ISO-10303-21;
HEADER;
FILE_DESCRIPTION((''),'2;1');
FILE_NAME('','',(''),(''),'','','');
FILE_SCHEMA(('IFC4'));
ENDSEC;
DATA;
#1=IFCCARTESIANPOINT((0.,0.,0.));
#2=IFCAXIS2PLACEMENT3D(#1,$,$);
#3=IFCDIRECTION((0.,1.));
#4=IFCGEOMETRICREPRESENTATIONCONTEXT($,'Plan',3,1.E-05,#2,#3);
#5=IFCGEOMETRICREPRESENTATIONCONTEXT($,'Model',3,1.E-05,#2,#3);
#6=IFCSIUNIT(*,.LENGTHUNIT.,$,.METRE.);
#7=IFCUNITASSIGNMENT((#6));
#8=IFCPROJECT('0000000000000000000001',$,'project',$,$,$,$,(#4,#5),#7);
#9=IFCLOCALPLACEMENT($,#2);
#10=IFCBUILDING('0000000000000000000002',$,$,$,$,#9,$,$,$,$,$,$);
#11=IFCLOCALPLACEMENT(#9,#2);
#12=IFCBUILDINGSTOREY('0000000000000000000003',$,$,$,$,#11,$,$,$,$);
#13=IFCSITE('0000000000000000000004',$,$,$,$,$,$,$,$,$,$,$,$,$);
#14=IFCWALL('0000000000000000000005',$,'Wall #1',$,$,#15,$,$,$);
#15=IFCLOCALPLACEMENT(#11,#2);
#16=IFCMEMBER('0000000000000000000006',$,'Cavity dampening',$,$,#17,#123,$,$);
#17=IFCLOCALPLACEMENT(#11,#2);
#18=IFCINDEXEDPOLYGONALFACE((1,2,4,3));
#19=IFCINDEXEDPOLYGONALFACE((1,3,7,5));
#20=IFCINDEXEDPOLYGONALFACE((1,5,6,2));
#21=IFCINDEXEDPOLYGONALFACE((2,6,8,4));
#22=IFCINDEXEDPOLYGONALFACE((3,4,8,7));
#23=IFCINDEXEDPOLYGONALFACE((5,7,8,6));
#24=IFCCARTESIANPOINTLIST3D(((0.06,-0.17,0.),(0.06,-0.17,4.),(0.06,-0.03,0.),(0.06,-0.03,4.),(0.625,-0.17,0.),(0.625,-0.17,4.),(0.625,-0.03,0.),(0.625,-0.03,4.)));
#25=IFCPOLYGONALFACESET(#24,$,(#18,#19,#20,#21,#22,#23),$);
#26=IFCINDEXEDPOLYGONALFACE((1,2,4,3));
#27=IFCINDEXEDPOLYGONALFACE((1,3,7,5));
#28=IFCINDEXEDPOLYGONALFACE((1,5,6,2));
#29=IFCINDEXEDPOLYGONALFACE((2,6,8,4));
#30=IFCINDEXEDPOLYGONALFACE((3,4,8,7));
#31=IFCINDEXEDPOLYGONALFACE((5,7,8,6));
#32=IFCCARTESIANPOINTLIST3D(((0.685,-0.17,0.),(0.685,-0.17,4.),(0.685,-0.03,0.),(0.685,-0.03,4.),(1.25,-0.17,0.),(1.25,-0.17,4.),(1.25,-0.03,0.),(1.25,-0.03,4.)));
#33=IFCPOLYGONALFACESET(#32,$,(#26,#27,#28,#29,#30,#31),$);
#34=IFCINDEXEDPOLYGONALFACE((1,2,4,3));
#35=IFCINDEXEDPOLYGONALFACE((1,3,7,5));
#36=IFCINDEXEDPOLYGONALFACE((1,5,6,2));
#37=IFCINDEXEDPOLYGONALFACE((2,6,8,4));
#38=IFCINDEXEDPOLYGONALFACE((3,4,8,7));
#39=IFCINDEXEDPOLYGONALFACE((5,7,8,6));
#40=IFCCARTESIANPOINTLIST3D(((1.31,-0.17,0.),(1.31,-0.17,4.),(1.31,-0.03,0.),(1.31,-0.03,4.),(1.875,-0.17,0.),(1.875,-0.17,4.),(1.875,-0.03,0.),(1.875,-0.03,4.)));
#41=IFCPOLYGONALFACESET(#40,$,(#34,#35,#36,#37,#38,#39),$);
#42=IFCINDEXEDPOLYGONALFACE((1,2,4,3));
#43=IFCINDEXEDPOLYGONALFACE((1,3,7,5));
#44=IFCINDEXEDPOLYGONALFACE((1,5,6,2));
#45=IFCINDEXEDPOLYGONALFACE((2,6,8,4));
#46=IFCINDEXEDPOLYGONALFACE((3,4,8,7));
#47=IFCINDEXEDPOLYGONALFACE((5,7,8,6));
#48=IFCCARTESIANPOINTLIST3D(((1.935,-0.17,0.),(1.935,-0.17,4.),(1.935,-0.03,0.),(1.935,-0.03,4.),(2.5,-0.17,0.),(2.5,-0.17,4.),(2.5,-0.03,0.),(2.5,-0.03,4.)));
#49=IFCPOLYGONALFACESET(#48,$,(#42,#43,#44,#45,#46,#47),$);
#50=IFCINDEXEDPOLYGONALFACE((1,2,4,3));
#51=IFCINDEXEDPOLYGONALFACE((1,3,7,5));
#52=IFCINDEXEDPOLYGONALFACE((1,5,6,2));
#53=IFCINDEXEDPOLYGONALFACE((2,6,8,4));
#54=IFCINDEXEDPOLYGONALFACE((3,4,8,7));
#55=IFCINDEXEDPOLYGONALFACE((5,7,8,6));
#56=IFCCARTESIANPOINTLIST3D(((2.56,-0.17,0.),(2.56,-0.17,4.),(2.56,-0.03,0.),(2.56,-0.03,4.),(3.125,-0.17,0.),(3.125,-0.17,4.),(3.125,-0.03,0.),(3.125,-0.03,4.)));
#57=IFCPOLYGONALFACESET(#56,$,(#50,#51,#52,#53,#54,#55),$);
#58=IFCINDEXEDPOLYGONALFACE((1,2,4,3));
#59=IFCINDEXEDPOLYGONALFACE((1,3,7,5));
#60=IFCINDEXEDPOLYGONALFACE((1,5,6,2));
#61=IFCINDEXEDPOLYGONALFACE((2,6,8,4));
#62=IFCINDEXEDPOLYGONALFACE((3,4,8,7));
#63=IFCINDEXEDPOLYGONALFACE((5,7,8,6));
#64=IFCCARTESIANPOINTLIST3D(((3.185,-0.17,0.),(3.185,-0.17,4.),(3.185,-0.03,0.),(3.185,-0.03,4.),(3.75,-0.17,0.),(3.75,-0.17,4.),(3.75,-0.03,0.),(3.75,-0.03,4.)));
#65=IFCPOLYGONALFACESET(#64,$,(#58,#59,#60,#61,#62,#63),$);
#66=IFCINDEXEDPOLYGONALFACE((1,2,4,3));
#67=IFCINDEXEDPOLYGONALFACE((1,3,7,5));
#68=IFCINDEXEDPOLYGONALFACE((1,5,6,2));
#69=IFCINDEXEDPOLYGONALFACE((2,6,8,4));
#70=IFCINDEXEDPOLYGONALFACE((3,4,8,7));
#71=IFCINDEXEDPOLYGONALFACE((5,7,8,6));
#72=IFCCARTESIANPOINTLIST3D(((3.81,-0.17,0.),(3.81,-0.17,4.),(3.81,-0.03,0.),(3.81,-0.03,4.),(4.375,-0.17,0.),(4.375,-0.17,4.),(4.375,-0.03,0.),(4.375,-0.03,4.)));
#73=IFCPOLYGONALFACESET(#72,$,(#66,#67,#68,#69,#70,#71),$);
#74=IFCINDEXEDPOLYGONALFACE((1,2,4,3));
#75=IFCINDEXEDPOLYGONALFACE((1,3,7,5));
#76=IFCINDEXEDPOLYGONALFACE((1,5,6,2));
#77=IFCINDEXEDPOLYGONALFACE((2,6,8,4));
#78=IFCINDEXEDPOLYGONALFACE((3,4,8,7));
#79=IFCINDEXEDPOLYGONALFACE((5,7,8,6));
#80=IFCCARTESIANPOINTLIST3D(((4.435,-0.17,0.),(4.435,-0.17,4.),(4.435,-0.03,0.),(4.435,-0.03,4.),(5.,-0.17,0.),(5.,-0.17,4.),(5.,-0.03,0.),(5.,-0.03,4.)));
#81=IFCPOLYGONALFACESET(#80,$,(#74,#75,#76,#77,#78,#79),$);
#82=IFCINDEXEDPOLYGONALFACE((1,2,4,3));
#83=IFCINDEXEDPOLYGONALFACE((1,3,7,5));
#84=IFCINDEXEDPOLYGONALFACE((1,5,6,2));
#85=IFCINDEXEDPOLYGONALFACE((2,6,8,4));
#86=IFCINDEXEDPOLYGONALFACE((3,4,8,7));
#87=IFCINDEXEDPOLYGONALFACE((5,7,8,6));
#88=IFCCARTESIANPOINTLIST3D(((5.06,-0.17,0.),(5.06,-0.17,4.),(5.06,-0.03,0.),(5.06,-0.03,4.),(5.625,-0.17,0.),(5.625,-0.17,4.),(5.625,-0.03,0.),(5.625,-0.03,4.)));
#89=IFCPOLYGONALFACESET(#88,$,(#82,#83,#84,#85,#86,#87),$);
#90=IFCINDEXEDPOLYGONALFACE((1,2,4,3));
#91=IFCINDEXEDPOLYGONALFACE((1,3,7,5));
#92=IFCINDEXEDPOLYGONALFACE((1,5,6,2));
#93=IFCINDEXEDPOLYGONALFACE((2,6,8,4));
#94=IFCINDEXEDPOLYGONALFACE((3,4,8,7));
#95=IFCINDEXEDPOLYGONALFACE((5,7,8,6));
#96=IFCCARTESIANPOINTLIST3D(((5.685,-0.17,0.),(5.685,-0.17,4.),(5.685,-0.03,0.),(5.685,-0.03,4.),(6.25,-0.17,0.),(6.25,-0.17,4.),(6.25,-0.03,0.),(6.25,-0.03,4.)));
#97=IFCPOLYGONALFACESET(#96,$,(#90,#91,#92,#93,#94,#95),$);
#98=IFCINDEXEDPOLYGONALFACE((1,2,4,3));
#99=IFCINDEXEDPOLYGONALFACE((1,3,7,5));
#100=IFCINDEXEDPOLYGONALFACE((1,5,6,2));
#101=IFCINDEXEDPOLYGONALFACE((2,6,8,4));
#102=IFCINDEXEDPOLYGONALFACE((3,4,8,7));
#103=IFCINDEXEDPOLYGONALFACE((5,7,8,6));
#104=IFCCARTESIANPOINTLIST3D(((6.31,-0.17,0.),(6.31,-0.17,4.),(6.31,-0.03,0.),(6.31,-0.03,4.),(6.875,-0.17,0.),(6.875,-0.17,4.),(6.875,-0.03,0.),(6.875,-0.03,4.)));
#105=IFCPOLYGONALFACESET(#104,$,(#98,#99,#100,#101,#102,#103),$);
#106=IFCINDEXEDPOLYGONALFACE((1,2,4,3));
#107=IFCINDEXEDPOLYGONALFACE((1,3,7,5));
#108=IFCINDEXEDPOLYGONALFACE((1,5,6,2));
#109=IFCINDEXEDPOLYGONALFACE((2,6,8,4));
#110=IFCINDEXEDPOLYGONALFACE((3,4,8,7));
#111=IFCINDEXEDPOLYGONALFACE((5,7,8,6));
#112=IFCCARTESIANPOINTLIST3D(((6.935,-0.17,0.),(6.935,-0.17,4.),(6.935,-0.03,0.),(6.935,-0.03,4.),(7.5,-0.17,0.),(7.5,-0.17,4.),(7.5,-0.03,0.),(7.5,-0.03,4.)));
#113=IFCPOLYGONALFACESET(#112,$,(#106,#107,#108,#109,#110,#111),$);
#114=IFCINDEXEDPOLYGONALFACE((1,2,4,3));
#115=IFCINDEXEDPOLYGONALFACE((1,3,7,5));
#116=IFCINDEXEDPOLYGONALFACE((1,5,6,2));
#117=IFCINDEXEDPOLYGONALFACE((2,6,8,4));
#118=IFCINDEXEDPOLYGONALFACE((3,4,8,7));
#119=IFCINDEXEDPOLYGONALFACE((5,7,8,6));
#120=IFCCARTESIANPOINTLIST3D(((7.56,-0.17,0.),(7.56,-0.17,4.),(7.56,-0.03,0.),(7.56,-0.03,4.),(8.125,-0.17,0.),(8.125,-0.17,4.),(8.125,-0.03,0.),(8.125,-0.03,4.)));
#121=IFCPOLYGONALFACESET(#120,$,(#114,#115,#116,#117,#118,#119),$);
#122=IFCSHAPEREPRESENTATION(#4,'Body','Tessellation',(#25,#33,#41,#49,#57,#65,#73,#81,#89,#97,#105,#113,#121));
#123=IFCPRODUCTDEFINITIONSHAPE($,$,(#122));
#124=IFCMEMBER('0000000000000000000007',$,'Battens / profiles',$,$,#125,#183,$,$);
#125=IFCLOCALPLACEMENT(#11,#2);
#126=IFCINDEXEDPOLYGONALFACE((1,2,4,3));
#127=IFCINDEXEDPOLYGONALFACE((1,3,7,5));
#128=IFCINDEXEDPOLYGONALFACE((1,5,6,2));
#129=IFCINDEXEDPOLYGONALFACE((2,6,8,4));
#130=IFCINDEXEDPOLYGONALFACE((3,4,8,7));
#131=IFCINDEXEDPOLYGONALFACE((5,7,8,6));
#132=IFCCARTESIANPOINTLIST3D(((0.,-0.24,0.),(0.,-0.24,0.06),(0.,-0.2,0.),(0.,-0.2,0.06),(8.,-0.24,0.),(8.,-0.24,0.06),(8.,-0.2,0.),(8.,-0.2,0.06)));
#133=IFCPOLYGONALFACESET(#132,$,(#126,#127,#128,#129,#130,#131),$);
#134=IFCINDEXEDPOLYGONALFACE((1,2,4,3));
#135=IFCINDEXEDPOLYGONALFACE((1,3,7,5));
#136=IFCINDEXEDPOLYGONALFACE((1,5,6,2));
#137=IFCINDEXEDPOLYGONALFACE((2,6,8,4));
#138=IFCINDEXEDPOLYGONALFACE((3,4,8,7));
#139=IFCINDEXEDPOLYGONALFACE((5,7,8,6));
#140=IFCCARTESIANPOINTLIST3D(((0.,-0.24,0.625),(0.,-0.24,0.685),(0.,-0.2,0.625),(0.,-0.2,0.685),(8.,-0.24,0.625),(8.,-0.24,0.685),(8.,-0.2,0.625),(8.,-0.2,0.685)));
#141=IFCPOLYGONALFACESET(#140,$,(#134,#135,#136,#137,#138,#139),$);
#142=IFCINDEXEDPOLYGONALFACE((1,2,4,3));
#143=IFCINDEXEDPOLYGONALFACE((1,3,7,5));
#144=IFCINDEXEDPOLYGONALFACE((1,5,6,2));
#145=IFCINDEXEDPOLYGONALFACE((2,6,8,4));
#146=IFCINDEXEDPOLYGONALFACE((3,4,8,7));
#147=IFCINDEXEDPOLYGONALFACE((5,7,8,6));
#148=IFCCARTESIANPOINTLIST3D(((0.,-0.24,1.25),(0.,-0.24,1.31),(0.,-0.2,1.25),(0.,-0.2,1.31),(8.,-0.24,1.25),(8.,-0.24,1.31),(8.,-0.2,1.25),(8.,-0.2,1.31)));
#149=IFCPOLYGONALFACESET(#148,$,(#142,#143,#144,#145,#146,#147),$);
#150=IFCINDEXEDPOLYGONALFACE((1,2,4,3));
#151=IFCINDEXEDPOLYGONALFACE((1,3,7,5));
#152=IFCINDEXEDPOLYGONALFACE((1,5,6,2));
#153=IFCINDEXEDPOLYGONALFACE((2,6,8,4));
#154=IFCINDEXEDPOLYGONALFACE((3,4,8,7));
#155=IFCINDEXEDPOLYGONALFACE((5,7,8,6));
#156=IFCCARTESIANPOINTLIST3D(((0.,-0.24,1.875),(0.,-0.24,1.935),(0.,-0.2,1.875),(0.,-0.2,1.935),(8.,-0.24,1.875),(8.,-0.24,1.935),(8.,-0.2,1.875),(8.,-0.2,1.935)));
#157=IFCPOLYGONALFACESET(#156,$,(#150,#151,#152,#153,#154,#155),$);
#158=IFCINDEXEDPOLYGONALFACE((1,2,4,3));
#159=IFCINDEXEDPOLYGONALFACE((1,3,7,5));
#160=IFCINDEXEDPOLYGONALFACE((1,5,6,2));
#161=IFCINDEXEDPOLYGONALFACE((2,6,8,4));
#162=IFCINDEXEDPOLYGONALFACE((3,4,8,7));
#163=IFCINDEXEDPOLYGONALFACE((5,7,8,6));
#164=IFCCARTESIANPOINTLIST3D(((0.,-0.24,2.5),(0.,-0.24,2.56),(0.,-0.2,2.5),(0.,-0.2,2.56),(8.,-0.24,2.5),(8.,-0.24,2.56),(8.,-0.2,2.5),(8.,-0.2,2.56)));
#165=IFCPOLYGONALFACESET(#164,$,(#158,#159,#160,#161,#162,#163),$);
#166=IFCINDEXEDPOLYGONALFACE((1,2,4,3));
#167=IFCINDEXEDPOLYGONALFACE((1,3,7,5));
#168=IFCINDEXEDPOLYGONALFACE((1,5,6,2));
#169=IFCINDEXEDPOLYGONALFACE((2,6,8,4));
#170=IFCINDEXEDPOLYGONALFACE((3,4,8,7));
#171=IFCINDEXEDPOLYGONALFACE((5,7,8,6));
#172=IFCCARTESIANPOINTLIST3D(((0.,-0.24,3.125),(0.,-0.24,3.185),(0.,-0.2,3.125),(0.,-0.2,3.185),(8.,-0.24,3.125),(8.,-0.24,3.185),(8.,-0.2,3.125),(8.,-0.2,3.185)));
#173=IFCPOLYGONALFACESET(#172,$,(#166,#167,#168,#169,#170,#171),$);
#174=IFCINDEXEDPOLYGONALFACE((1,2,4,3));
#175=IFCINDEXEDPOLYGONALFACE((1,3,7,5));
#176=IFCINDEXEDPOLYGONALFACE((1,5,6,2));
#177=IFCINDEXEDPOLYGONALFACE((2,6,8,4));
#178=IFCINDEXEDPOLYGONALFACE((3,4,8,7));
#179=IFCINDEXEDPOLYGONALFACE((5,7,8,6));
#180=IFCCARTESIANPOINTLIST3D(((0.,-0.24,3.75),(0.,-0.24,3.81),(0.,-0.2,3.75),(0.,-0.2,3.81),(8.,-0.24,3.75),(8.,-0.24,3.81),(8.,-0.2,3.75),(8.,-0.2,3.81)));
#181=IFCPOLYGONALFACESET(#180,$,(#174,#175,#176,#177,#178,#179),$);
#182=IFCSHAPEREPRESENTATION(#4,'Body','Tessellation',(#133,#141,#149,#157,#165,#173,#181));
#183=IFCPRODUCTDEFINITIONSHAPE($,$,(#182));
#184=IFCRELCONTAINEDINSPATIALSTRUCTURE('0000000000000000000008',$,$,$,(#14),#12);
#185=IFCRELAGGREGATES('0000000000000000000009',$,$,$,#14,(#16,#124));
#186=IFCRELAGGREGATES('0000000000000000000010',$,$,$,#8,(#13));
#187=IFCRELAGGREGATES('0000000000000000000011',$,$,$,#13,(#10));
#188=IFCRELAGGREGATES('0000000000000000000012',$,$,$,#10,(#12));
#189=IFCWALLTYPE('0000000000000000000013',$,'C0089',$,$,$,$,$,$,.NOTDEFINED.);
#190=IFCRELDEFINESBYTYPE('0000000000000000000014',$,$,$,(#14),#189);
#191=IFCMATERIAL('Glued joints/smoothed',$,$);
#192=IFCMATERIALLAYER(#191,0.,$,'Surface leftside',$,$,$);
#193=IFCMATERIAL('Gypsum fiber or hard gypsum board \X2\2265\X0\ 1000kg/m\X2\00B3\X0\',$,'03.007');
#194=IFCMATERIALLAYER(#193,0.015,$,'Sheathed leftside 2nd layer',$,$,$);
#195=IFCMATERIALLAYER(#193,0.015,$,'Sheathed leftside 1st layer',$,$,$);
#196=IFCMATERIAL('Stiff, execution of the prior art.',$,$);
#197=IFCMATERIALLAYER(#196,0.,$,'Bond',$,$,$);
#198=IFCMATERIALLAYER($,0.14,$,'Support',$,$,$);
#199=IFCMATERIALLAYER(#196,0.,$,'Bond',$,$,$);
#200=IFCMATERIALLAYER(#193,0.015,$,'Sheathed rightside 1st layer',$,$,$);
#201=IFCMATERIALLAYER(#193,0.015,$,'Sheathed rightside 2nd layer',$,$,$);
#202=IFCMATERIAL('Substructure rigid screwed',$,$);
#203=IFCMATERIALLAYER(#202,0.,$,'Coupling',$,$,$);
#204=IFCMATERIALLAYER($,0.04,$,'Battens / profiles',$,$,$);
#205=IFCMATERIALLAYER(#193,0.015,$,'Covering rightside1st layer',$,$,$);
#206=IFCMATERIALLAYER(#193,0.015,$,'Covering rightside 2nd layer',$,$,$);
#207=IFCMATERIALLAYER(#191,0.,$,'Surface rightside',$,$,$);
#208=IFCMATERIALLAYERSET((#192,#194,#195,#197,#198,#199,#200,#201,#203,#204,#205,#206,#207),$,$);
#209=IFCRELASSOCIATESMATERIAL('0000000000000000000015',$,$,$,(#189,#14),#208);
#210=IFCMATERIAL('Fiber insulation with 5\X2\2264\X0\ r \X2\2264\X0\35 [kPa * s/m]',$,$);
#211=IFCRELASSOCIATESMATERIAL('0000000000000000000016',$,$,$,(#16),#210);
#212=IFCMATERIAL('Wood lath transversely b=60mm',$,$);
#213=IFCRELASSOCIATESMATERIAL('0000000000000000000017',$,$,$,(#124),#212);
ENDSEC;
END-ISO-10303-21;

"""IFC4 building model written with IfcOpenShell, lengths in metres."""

from ifc_helpers import new_model, si_unit, direction, frame, frame_2d, origin, place, context, project, spatial, rectangle, extrude, material, layer, layer_set, type_object, element, aggregate, save


model = new_model("IFC4")

# Units and contexts
plan_context = context("Plan", 3, precision=1e-05, world=origin(), true_north=direction((0.0, 1.0)))
model_context = context("Model", 3, precision=1e-05, world=origin(), true_north=direction((0.0, 1.0)))
ifc_project = project(units=[si_unit("LENGTHUNIT", "METRE")], contexts=[plan_context, model_context])

# Site, building, storey
site = spatial("IfcSite", under=ifc_project)
building_placement = place(None, origin())
building = spatial("IfcBuilding", under=site, at=building_placement)
storey_placement = place(building_placement, origin())
storey = spatial("IfcBuildingStorey", under=building, at=storey_placement)

# Wall, members
ifc_material_1 = material(Name="Glued joints/smoothed")
ifc_layer_1 = layer(ifc_material_1, 0.0, Name="Surface leftside")
ifc_material_2 = material(Name="Gypsum fiber or hard gypsum board ≥ 1000kg/m³", Category="03.007")
ifc_layer_2 = layer(ifc_material_2, 0.015, Name="Sheathed leftside 2nd layer")
ifc_layer_3 = layer(ifc_material_2, 0.015, Name="Sheathed leftside 1st layer")
ifc_material_3 = material(Name="Stiff, execution of the prior art.")
ifc_layer_4 = layer(ifc_material_3, 0.0, Name="Bond")
ifc_layer_5 = layer(None, 0.14, Name="Support")
ifc_layer_6 = layer(ifc_material_3, 0.0, Name="Bond")
ifc_layer_7 = layer(ifc_material_2, 0.015, Name="Sheathed rightside 1st layer")
ifc_layer_8 = layer(ifc_material_2, 0.015, Name="Sheathed rightside 2nd layer")
ifc_material_4 = material(Name="Substructure rigid screwed")
ifc_layer_9 = layer(ifc_material_4, 0.0, Name="Coupling")
ifc_layer_10 = layer(None, 0.04, Name="Battens / profiles")
ifc_layer_11 = layer(ifc_material_2, 0.015, Name="Covering rightside1st layer")
ifc_layer_12 = layer(ifc_material_2, 0.015, Name="Covering rightside 2nd layer")
ifc_layer_13 = layer(ifc_material_1, 0.0, Name="Surface rightside")
ifc_layer_set = layer_set([ifc_layer_1, ifc_layer_2, ifc_layer_3, ifc_layer_4, ifc_layer_5, ifc_layer_6, ifc_layer_7, ifc_layer_8, ifc_layer_9, ifc_layer_10, ifc_layer_11, ifc_layer_12, ifc_layer_13])
wall_type = type_object("IfcWallType", Name="C0089", PredefinedType="NOTDEFINED", material=ifc_layer_set)
wall_placement = place(None, frame((0.0, 0.0, 0.0), z_axis=(0.0, -1.0, 0.0), x_axis=(1.0, 0.0, 0.0)))
wall = element("IfcWall", 1, at=wall_placement, inside=storey, type_object=wall_type, material=ifc_layer_set, Name="Wall #1")
ifc_material_5 = material(Name="Fiber insulation with 5≤ r ≤35 [kPa * s/m]")
member_1_placement = place(wall_placement, origin())
member_1 = element("IfcMember", 2, at=member_1_placement, material=ifc_material_5, Name="Cavity dampening", context=plan_context, shape_type="SweptSolid", body=[
    extrude(rectangle(XDim=0.565, YDim=0.14, at=frame_2d((0.2825, 0.07), x_axis=(1.0, 0.0))), frame((0.06, 4.0, 0.03), z_axis=(0.0, -1.0, 0.0), x_axis=(1.0, 0.0, 0.0)), (0.0, 0.0, 1.0), 4.0),
    extrude(rectangle(XDim=0.565, YDim=0.14, at=frame_2d((0.2825, 0.07), x_axis=(1.0, 0.0))), frame((0.685, 4.0, 0.03), z_axis=(0.0, -1.0, 0.0), x_axis=(1.0, 0.0, 0.0)), (0.0, 0.0, 1.0), 4.0),
    extrude(rectangle(XDim=0.565, YDim=0.14, at=frame_2d((0.2825, 0.07), x_axis=(1.0, 0.0))), frame((1.31, 4.0, 0.03), z_axis=(0.0, -1.0, 0.0), x_axis=(1.0, 0.0, 0.0)), (0.0, 0.0, 1.0), 4.0),
    extrude(rectangle(XDim=0.565, YDim=0.14, at=frame_2d((0.2825, 0.07), x_axis=(1.0, 0.0))), frame((1.935, 4.0, 0.03), z_axis=(0.0, -1.0, 0.0), x_axis=(1.0, 0.0, 0.0)), (0.0, 0.0, 1.0), 4.0),
    extrude(rectangle(XDim=0.565, YDim=0.14, at=frame_2d((0.2825, 0.07), x_axis=(1.0, 0.0))), frame((2.56, 4.0, 0.03), z_axis=(0.0, -1.0, 0.0), x_axis=(1.0, 0.0, 0.0)), (0.0, 0.0, 1.0), 4.0),
    extrude(rectangle(XDim=0.565, YDim=0.14, at=frame_2d((0.2825, 0.07), x_axis=(1.0, 0.0))), frame((3.185, 4.0, 0.03), z_axis=(0.0, -1.0, 0.0), x_axis=(1.0, 0.0, 0.0)), (0.0, 0.0, 1.0), 4.0),
    extrude(rectangle(XDim=0.565, YDim=0.14, at=frame_2d((0.2825, 0.07), x_axis=(1.0, 0.0))), frame((3.81, 4.0, 0.03), z_axis=(0.0, -1.0, 0.0), x_axis=(1.0, 0.0, 0.0)), (0.0, 0.0, 1.0), 4.0),
    extrude(rectangle(XDim=0.565, YDim=0.14, at=frame_2d((0.2825, 0.07), x_axis=(1.0, 0.0))), frame((4.435, 4.0, 0.03), z_axis=(0.0, -1.0, 0.0), x_axis=(1.0, 0.0, 0.0)), (0.0, 0.0, 1.0), 4.0),
    extrude(rectangle(XDim=0.565, YDim=0.14, at=frame_2d((0.2825, 0.07), x_axis=(1.0, 0.0))), frame((5.06, 4.0, 0.03), z_axis=(0.0, -1.0, 0.0), x_axis=(1.0, 0.0, 0.0)), (0.0, 0.0, 1.0), 4.0),
    extrude(rectangle(XDim=0.565, YDim=0.14, at=frame_2d((0.2825, 0.07), x_axis=(1.0, 0.0))), frame((5.685, 4.0, 0.03), z_axis=(0.0, -1.0, 0.0), x_axis=(1.0, 0.0, 0.0)), (0.0, 0.0, 1.0), 4.0),
    extrude(rectangle(XDim=0.565, YDim=0.14, at=frame_2d((0.2825, 0.07), x_axis=(1.0, 0.0))), frame((6.31, 4.0, 0.03), z_axis=(0.0, -1.0, 0.0), x_axis=(1.0, 0.0, 0.0)), (0.0, 0.0, 1.0), 4.0),
    extrude(rectangle(XDim=0.565, YDim=0.14, at=frame_2d((0.2825, 0.07), x_axis=(1.0, 0.0))), frame((6.935, 4.0, 0.03), z_axis=(0.0, -1.0, 0.0), x_axis=(1.0, 0.0, 0.0)), (0.0, 0.0, 1.0), 4.0),
    extrude(rectangle(XDim=0.565, YDim=0.14, at=frame_2d((0.2825, 0.07), x_axis=(1.0, 0.0))), frame((7.56, 4.0, 0.03), z_axis=(0.0, -1.0, 0.0), x_axis=(1.0, 0.0, 0.0)), (0.0, 0.0, 1.0), 4.0),
])
ifc_material_6 = material(Name="Wood lath transversely b=60mm")
member_2_placement = place(wall_placement, origin())
member_2 = element("IfcMember", 3, at=member_2_placement, material=ifc_material_6, Name="Battens / profiles", context=plan_context, shape_type="SweptSolid", body=[
    extrude(rectangle(XDim=0.06, YDim=0.04, at=frame_2d((0.03, 0.02), x_axis=(1.0, 0.0))), frame((0.0, 0.0, 0.2), z_axis=(1.0, 0.0, 0.0), x_axis=(0.0, 1.0, 0.0)), (0.0, 0.0, 1.0), 8.0),
    extrude(rectangle(XDim=0.06, YDim=0.04, at=frame_2d((0.03, 0.02), x_axis=(1.0, 0.0))), frame((0.0, 0.625, 0.2), z_axis=(1.0, 0.0, 0.0), x_axis=(0.0, 1.0, 0.0)), (0.0, 0.0, 1.0), 8.0),
    extrude(rectangle(XDim=0.06, YDim=0.04, at=frame_2d((0.03, 0.02), x_axis=(1.0, 0.0))), frame((0.0, 1.25, 0.2), z_axis=(1.0, 0.0, 0.0), x_axis=(0.0, 1.0, 0.0)), (0.0, 0.0, 1.0), 8.0),
    extrude(rectangle(XDim=0.06, YDim=0.04, at=frame_2d((0.03, 0.02), x_axis=(1.0, 0.0))), frame((0.0, 1.875, 0.2), z_axis=(1.0, 0.0, 0.0), x_axis=(0.0, 1.0, 0.0)), (0.0, 0.0, 1.0), 8.0),
    extrude(rectangle(XDim=0.06, YDim=0.04, at=frame_2d((0.03, 0.02), x_axis=(1.0, 0.0))), frame((0.0, 2.5, 0.2), z_axis=(1.0, 0.0, 0.0), x_axis=(0.0, 1.0, 0.0)), (0.0, 0.0, 1.0), 8.0),
    extrude(rectangle(XDim=0.06, YDim=0.04, at=frame_2d((0.03, 0.02), x_axis=(1.0, 0.0))), frame((0.0, 3.125, 0.2), z_axis=(1.0, 0.0, 0.0), x_axis=(0.0, 1.0, 0.0)), (0.0, 0.0, 1.0), 8.0),
    extrude(rectangle(XDim=0.06, YDim=0.04, at=frame_2d((0.03, 0.02), x_axis=(1.0, 0.0))), frame((0.0, 3.75, 0.2), z_axis=(1.0, 0.0, 0.0), x_axis=(0.0, 1.0, 0.0)), (0.0, 0.0, 1.0), 8.0),
])
aggregate(wall, [member_1, member_2])

save(model, "model.ifc")
